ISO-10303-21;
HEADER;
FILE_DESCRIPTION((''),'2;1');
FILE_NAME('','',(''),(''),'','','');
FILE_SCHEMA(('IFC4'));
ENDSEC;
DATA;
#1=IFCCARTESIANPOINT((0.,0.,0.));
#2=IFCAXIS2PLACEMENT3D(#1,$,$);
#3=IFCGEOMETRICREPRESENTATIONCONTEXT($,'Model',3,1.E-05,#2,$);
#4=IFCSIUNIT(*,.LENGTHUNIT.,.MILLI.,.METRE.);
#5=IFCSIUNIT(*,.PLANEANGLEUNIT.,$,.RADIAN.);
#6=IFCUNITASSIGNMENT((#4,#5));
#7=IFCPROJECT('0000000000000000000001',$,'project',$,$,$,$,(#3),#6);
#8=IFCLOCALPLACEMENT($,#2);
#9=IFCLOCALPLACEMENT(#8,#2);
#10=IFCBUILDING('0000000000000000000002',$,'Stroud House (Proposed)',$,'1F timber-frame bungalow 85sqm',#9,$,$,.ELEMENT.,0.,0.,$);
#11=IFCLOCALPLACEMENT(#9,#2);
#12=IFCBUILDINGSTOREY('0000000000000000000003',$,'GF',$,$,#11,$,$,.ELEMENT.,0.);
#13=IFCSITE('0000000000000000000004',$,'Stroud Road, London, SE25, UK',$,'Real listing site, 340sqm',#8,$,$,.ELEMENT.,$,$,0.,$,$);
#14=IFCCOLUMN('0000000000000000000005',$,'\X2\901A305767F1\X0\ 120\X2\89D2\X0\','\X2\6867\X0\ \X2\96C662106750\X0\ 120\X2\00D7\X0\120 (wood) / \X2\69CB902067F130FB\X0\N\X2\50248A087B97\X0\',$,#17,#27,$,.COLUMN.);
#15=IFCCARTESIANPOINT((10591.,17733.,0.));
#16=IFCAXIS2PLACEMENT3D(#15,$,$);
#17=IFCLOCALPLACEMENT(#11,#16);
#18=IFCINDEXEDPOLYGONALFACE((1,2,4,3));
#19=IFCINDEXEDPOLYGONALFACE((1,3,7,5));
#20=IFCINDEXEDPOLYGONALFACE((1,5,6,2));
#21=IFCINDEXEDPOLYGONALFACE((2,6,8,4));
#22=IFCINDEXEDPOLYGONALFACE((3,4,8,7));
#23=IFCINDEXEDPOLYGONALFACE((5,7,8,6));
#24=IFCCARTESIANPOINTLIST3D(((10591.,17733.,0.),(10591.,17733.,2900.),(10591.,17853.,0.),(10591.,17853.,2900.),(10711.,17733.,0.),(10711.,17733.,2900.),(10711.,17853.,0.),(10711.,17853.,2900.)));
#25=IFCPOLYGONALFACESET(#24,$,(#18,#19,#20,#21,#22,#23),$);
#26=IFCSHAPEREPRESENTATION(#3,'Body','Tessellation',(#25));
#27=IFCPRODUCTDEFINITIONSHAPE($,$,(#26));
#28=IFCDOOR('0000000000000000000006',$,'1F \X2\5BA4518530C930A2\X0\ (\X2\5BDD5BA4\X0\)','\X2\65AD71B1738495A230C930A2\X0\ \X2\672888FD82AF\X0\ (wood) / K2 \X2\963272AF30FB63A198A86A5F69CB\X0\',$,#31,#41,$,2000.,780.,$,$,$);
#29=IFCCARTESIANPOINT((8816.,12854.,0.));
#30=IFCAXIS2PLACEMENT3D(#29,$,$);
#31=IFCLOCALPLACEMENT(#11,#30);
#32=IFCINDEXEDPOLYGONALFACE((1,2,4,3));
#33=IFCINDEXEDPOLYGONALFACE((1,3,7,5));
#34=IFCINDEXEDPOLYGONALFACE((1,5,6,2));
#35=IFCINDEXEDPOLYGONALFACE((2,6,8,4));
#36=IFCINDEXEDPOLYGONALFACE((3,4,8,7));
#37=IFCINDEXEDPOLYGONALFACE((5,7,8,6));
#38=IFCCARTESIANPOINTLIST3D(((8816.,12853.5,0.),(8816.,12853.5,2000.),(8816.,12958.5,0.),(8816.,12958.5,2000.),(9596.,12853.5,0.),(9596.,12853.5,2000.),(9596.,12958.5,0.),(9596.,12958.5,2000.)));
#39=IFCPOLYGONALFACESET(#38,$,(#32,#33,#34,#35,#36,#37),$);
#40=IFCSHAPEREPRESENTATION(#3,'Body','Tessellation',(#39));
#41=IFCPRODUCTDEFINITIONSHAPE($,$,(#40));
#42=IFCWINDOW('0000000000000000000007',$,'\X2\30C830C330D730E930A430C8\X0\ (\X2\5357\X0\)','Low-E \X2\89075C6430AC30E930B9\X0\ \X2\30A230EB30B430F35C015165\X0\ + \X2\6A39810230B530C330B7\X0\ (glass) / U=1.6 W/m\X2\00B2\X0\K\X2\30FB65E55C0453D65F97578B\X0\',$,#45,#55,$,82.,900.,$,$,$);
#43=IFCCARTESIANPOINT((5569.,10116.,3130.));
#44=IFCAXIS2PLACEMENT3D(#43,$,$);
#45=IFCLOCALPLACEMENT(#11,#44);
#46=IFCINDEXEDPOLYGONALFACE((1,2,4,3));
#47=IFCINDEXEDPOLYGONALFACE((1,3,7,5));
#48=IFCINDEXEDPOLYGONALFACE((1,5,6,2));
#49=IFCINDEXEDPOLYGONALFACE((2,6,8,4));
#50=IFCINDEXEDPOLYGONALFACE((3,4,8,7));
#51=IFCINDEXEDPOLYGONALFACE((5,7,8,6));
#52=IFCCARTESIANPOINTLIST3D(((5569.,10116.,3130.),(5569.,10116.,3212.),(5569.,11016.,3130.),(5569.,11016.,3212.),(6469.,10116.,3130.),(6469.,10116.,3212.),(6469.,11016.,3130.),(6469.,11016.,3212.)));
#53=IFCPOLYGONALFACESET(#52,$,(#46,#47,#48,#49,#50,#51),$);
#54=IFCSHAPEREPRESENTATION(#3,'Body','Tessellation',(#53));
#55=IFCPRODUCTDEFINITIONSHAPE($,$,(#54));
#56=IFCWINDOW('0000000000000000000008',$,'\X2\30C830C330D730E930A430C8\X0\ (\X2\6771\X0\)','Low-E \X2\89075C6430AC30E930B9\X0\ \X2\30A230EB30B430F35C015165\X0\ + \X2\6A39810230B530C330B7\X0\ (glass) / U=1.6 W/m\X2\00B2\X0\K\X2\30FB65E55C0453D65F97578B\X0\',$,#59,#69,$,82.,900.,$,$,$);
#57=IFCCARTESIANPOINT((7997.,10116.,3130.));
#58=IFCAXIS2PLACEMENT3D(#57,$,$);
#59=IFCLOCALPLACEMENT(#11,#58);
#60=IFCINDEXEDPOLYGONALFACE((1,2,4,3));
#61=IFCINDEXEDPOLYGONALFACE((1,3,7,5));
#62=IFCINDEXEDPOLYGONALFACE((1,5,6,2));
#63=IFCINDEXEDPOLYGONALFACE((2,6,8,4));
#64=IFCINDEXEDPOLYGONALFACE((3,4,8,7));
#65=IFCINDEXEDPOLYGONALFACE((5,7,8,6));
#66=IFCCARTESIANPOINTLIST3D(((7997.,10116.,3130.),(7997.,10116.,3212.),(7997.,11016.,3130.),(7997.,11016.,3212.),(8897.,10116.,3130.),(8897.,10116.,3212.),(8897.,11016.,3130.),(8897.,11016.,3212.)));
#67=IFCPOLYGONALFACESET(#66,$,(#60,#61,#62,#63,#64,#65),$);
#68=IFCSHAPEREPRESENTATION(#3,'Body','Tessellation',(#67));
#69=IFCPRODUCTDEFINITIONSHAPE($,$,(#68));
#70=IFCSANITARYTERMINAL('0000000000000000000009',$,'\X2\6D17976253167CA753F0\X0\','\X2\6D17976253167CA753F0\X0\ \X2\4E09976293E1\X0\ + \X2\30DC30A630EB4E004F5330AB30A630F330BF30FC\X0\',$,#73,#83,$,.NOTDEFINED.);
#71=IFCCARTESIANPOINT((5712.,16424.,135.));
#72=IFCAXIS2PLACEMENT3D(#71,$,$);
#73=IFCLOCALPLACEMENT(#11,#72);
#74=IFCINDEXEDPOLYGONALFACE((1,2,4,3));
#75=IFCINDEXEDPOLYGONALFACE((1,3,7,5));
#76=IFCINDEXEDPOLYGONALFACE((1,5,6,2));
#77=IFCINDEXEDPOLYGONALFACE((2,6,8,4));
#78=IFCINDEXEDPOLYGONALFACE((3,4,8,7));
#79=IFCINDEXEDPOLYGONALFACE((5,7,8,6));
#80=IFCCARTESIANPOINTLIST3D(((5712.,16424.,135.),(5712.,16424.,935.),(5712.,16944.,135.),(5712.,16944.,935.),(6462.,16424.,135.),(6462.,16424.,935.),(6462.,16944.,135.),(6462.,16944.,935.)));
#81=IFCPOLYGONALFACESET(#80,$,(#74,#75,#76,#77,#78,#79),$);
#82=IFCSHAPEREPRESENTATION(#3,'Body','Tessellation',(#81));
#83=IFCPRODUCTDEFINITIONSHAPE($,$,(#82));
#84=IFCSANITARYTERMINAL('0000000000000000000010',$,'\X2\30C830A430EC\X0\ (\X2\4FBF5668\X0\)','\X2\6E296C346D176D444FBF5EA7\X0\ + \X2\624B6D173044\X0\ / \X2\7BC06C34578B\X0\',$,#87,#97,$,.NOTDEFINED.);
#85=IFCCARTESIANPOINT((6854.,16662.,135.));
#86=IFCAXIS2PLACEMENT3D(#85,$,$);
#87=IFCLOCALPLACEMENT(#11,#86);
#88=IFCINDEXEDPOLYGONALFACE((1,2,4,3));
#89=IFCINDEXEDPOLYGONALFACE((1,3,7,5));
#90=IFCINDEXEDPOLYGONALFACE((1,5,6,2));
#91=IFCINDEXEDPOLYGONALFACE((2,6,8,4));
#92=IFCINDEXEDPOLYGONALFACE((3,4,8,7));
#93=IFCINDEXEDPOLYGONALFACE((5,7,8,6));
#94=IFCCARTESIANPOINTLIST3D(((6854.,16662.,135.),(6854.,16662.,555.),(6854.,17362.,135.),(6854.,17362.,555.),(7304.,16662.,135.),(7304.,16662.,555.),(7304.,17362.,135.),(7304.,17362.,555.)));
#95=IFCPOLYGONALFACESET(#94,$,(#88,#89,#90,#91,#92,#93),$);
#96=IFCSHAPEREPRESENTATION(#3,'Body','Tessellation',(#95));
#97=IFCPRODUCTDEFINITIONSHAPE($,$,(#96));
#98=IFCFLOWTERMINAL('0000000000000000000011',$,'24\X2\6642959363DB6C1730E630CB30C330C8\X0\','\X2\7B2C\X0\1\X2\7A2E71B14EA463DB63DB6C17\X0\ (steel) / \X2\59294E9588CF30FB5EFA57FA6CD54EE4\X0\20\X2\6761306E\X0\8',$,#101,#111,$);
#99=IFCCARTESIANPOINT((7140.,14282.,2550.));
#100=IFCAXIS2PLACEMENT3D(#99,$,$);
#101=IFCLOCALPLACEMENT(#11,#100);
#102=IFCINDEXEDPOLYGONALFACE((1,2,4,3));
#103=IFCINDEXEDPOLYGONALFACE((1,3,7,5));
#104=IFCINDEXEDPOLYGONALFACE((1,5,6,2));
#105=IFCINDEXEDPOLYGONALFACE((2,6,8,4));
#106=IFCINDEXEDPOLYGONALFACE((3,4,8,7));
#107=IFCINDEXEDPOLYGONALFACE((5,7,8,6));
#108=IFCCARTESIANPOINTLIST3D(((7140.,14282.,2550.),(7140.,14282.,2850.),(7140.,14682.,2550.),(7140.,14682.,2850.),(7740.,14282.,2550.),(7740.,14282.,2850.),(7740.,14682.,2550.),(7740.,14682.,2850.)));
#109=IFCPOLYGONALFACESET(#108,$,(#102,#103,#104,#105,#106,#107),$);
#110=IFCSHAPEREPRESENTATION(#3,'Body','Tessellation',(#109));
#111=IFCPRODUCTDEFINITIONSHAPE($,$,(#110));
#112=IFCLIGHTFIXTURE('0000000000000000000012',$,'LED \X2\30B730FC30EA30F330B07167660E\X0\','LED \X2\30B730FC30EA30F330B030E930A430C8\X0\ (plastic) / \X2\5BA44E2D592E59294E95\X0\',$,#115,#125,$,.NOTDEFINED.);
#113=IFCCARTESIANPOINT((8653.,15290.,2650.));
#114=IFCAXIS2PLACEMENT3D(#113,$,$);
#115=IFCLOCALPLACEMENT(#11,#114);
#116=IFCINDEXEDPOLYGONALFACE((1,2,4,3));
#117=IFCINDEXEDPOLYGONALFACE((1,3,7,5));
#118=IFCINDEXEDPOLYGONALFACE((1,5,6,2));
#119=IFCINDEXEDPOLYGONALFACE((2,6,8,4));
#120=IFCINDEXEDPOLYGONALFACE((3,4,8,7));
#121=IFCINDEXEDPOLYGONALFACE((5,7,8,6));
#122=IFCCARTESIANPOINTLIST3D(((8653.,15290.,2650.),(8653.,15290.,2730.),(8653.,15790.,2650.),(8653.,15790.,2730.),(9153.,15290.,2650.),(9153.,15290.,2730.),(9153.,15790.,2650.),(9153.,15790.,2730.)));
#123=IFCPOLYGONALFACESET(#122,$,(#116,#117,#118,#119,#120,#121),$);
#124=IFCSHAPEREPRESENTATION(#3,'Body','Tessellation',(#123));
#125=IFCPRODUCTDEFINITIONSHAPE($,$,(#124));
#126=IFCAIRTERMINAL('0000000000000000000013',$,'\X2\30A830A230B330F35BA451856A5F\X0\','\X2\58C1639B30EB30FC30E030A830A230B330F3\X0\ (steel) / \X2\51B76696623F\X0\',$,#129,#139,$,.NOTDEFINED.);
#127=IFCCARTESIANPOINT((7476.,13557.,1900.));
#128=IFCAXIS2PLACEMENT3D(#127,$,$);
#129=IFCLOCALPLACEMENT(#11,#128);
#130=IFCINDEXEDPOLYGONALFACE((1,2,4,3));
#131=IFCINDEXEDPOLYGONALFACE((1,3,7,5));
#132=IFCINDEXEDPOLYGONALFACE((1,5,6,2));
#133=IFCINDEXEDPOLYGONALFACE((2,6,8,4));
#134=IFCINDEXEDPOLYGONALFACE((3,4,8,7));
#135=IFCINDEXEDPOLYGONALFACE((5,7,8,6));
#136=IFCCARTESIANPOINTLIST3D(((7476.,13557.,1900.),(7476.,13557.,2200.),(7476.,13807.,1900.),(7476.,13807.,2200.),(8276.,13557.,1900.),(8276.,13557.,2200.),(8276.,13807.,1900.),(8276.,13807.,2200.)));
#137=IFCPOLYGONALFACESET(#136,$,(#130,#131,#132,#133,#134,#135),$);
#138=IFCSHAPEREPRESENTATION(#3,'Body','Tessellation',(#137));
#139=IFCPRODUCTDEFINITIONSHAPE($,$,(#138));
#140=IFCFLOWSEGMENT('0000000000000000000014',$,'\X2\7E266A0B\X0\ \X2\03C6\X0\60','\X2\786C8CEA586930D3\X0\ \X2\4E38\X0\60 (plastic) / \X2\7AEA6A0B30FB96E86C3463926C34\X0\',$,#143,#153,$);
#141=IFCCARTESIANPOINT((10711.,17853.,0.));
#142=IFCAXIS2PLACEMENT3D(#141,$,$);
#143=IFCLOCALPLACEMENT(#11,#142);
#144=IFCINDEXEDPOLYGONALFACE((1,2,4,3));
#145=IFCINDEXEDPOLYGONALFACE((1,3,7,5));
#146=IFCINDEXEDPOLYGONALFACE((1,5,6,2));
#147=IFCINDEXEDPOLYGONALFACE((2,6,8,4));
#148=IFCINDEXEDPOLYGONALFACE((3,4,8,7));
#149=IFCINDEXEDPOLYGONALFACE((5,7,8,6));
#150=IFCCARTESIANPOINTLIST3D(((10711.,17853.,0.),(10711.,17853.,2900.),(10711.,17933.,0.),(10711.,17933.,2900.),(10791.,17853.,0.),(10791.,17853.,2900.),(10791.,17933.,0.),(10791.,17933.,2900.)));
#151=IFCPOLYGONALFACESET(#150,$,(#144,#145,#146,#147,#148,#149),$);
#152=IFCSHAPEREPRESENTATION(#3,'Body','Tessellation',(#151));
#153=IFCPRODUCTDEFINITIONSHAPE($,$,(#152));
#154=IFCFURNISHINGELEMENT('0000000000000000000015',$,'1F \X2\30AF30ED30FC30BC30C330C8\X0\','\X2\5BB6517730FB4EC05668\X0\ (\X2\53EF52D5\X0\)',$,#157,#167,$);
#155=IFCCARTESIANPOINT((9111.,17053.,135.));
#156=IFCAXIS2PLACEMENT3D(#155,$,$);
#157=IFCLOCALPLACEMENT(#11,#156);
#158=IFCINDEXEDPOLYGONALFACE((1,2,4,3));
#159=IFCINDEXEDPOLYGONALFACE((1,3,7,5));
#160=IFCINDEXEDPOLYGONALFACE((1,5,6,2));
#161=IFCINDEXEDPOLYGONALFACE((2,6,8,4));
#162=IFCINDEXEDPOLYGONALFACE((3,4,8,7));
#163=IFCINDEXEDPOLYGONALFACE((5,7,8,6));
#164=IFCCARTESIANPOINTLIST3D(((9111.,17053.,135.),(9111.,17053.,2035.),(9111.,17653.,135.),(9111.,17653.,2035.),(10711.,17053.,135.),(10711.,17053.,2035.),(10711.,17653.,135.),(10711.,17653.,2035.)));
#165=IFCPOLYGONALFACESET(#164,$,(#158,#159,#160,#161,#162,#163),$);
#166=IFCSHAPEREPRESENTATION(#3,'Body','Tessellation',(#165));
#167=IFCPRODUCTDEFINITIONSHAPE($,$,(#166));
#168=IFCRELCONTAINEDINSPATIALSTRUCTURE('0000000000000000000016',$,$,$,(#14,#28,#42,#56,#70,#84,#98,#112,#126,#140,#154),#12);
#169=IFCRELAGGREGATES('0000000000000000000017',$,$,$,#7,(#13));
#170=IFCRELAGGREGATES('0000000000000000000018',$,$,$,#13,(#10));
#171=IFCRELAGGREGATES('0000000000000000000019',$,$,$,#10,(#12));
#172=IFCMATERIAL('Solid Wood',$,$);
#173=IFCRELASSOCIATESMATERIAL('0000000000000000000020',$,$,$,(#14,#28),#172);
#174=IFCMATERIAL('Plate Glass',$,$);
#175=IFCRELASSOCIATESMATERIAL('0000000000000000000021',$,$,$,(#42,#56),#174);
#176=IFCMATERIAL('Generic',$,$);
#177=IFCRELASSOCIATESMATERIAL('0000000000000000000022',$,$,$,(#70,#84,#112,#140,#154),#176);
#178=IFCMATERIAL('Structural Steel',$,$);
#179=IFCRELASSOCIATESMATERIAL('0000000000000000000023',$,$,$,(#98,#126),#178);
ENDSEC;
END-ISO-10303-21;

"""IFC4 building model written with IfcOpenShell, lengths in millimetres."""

from ifc_helpers import new_model, si_unit, frame, frame_2d, origin, place, context, project, spatial, rectangle, extrude, material, element, save


model = new_model("IFC4")

# Units and contexts
model_context = context("Model", 3, precision=1e-05, world=origin())
ifc_project = project(units=[si_unit("LENGTHUNIT", "METRE", prefix="MILLI"), si_unit("PLANEANGLEUNIT", "RADIAN")], contexts=[model_context])

# Site, building, storey
site_placement = place(None, origin())
site = spatial("IfcSite", under=ifc_project, at=site_placement, Name="Stroud Road, London, SE25, UK", ObjectType="Real listing site, 340sqm", CompositionType="ELEMENT", RefElevation=0.0)
building_placement = place(site_placement, origin())
building = spatial("IfcBuilding", under=site, at=building_placement, Name="Stroud House (Proposed)", ObjectType="1F timber-frame bungalow 85sqm", CompositionType="ELEMENT", ElevationOfRefHeight=0.0, ElevationOfTerrain=0.0)
storey_placement = place(building_placement, origin())
storey = spatial("IfcBuildingStorey", under=building, at=storey_placement, Name="GF", CompositionType="ELEMENT", Elevation=0.0)

# Column
ifc_material_1 = material(Name="Solid Wood")
column_1_placement = place(storey_placement, frame((10591.0, 17733.0, 0.0)))
element("IfcColumn", 1, at=column_1_placement, inside=storey, material=ifc_material_1, Name="通し柱 120角", Description="桧 集成材 120×120 (wood) / 構造柱・N値計算", PredefinedType="COLUMN", context=model_context, shape_type="SweptSolid", body=[
    extrude(rectangle(XDim=120.0, YDim=120.0, at=frame_2d((60.0, 60.0))), frame((10591.0, 17733.0, 0.0)), (0.0, 0.0, 1.0), 2900.0),
])

# Door
door_placement = place(storey_placement, frame((8816.0, 12854.0, 0.0)))
element("IfcDoor", 2, at=door_placement, inside=storey, material=ifc_material_1, Name="1F 室内ドア (寝室)", Description="断熱玄関ドア 木製芯 (wood) / K2 防犯・採風機構", OverallHeight=2000.0, OverallWidth=780.0, context=model_context, shape_type="SweptSolid", body=[
    extrude(rectangle(XDim=780.0, YDim=105.0, at=frame_2d((390.0, 52.0))), frame((8816.0, 12854.0, 0.0)), (0.0, 0.0, 1.0), 2000.0),
])

# Windows
ifc_material_2 = material(Name="Plate Glass")
window_1_placement = place(storey_placement, frame((5569.0, 10116.0, 3130.0)))
element("IfcWindow", 3, at=window_1_placement, inside=storey, material=ifc_material_2, Name="トップライト (南)", Description="Low-E 複層ガラス アルゴン封入 + 樹脂サッシ (glass) / U=1.6 W/m²K・日射取得型", OverallHeight=82.0, OverallWidth=900.0, context=model_context, shape_type="SweptSolid", body=[
    extrude(rectangle(XDim=900.0, YDim=900.0, at=frame_2d((450.0, 450.0))), frame((5569.0, 10116.0, 3130.0)), (0.0, 0.0, 1.0), 82.0),
])
window_2_placement = place(storey_placement, frame((7997.0, 10116.0, 3130.0)))
element("IfcWindow", 4, at=window_2_placement, inside=storey, material=ifc_material_2, Name="トップライト (東)", Description="Low-E 複層ガラス アルゴン封入 + 樹脂サッシ (glass) / U=1.6 W/m²K・日射取得型", OverallHeight=82.0, OverallWidth=900.0, context=model_context, shape_type="SweptSolid", body=[
    extrude(rectangle(XDim=900.0, YDim=900.0, at=frame_2d((450.0, 450.0))), frame((7997.0, 10116.0, 3130.0)), (0.0, 0.0, 1.0), 82.0),
])

# Sanitary terminals
ifc_material_3 = material(Name="Generic")
sanitary_terminal_1_placement = place(storey_placement, frame((5712.0, 16424.0, 135.0)))
element("IfcSanitaryTerminal", 5, at=sanitary_terminal_1_placement, inside=storey, material=ifc_material_3, Name="洗面化粧台", Description="洗面化粧台 三面鏡 + ボウル一体カウンター", PredefinedType="NOTDEFINED", context=model_context, shape_type="SweptSolid", body=[
    extrude(rectangle(XDim=750.0, YDim=520.0, at=frame_2d((375.0, 260.0))), frame((5712.0, 16424.0, 135.0)), (0.0, 0.0, 1.0), 800.0),
])
sanitary_terminal_2_placement = place(storey_placement, frame((6854.0, 16662.0, 135.0)))
element("IfcSanitaryTerminal", 6, at=sanitary_terminal_2_placement, inside=storey, material=ifc_material_3, Name="トイレ (便器)", Description="温水洗浄便座 + 手洗い / 節水型", PredefinedType="NOTDEFINED", context=model_context, shape_type="SweptSolid", body=[
    extrude(rectangle(XDim=450.0, YDim=700.0, at=frame_2d((225.0, 350.0))), frame((6854.0, 16662.0, 135.0)), (0.0, 0.0, 1.0), 420.0),
])

# Flow terminal
ifc_material_4 = material(Name="Structural Steel")
flow_terminal_placement = place(storey_placement, frame((7140.0, 14282.0, 2550.0)))
element("IfcFlowTerminal", 7, at=flow_terminal_placement, inside=storey, material=ifc_material_4, Name="24時間換気ユニット", Description="第1種熱交換換気 (steel) / 天井裏・建基法令20条の8", context=model_context, shape_type="SweptSolid", body=[
    extrude(rectangle(XDim=600.0, YDim=400.0, at=frame_2d((300.0, 200.0))), frame((7140.0, 14282.0, 2550.0)), (0.0, 0.0, 1.0), 300.0),
])

# Light fixture
light_fixture_placement = place(storey_placement, frame((8653.0, 15290.0, 2650.0)))
element("IfcLightFixture", 8, at=light_fixture_placement, inside=storey, material=ifc_material_3, Name="LED シーリング照明", Description="LED シーリングライト (plastic) / 室中央天井", PredefinedType="NOTDEFINED", context=model_context, shape_type="SweptSolid", body=[
    extrude(rectangle(XDim=500.0, YDim=500.0, at=frame_2d((250.0, 250.0))), frame((8653.0, 15290.0, 2650.0)), (0.0, 0.0, 1.0), 80.0),
])

# Air terminal
air_terminal_placement = place(storey_placement, frame((7476.0, 13557.0, 1900.0)))
element("IfcAirTerminal", 9, at=air_terminal_placement, inside=storey, material=ifc_material_4, Name="エアコン室内機", Description="壁掛ルームエアコン (steel) / 冷暖房", PredefinedType="NOTDEFINED", context=model_context, shape_type="SweptSolid", body=[
    extrude(rectangle(XDim=800.0, YDim=250.0, at=frame_2d((400.0, 125.0))), frame((7476.0, 13557.0, 1900.0)), (0.0, 0.0, 1.0), 300.0),
])

# Flow segment
flow_segment_placement = place(storey_placement, frame((10711.0, 17853.0, 0.0)))
element("IfcFlowSegment", 10, at=flow_segment_placement, inside=storey, material=ifc_material_3, Name="縦樋 φ60", Description="硬質塩ビ 丸60 (plastic) / 竪樋・雨水排水", context=model_context, shape_type="SweptSolid", body=[
    extrude(rectangle(XDim=80.0, YDim=80.0, at=frame_2d((40.0, 40.0))), frame((10711.0, 17853.0, 0.0)), (0.0, 0.0, 1.0), 2900.0),
])

# Furnishing element
furnishing_placement = place(storey_placement, frame((9111.0, 17053.0, 135.0)))
element("IfcFurnishingElement", 11, at=furnishing_placement, inside=storey, material=ifc_material_3, Name="1F クローゼット", Description="家具・什器 (可動)", context=model_context, shape_type="SweptSolid", body=[
    extrude(rectangle(XDim=1600.0, YDim=600.0, at=frame_2d((800.0, 300.0))), frame((9111.0, 17053.0, 135.0)), (0.0, 0.0, 1.0), 1900.0),
])

save(model, "model.ifc")
